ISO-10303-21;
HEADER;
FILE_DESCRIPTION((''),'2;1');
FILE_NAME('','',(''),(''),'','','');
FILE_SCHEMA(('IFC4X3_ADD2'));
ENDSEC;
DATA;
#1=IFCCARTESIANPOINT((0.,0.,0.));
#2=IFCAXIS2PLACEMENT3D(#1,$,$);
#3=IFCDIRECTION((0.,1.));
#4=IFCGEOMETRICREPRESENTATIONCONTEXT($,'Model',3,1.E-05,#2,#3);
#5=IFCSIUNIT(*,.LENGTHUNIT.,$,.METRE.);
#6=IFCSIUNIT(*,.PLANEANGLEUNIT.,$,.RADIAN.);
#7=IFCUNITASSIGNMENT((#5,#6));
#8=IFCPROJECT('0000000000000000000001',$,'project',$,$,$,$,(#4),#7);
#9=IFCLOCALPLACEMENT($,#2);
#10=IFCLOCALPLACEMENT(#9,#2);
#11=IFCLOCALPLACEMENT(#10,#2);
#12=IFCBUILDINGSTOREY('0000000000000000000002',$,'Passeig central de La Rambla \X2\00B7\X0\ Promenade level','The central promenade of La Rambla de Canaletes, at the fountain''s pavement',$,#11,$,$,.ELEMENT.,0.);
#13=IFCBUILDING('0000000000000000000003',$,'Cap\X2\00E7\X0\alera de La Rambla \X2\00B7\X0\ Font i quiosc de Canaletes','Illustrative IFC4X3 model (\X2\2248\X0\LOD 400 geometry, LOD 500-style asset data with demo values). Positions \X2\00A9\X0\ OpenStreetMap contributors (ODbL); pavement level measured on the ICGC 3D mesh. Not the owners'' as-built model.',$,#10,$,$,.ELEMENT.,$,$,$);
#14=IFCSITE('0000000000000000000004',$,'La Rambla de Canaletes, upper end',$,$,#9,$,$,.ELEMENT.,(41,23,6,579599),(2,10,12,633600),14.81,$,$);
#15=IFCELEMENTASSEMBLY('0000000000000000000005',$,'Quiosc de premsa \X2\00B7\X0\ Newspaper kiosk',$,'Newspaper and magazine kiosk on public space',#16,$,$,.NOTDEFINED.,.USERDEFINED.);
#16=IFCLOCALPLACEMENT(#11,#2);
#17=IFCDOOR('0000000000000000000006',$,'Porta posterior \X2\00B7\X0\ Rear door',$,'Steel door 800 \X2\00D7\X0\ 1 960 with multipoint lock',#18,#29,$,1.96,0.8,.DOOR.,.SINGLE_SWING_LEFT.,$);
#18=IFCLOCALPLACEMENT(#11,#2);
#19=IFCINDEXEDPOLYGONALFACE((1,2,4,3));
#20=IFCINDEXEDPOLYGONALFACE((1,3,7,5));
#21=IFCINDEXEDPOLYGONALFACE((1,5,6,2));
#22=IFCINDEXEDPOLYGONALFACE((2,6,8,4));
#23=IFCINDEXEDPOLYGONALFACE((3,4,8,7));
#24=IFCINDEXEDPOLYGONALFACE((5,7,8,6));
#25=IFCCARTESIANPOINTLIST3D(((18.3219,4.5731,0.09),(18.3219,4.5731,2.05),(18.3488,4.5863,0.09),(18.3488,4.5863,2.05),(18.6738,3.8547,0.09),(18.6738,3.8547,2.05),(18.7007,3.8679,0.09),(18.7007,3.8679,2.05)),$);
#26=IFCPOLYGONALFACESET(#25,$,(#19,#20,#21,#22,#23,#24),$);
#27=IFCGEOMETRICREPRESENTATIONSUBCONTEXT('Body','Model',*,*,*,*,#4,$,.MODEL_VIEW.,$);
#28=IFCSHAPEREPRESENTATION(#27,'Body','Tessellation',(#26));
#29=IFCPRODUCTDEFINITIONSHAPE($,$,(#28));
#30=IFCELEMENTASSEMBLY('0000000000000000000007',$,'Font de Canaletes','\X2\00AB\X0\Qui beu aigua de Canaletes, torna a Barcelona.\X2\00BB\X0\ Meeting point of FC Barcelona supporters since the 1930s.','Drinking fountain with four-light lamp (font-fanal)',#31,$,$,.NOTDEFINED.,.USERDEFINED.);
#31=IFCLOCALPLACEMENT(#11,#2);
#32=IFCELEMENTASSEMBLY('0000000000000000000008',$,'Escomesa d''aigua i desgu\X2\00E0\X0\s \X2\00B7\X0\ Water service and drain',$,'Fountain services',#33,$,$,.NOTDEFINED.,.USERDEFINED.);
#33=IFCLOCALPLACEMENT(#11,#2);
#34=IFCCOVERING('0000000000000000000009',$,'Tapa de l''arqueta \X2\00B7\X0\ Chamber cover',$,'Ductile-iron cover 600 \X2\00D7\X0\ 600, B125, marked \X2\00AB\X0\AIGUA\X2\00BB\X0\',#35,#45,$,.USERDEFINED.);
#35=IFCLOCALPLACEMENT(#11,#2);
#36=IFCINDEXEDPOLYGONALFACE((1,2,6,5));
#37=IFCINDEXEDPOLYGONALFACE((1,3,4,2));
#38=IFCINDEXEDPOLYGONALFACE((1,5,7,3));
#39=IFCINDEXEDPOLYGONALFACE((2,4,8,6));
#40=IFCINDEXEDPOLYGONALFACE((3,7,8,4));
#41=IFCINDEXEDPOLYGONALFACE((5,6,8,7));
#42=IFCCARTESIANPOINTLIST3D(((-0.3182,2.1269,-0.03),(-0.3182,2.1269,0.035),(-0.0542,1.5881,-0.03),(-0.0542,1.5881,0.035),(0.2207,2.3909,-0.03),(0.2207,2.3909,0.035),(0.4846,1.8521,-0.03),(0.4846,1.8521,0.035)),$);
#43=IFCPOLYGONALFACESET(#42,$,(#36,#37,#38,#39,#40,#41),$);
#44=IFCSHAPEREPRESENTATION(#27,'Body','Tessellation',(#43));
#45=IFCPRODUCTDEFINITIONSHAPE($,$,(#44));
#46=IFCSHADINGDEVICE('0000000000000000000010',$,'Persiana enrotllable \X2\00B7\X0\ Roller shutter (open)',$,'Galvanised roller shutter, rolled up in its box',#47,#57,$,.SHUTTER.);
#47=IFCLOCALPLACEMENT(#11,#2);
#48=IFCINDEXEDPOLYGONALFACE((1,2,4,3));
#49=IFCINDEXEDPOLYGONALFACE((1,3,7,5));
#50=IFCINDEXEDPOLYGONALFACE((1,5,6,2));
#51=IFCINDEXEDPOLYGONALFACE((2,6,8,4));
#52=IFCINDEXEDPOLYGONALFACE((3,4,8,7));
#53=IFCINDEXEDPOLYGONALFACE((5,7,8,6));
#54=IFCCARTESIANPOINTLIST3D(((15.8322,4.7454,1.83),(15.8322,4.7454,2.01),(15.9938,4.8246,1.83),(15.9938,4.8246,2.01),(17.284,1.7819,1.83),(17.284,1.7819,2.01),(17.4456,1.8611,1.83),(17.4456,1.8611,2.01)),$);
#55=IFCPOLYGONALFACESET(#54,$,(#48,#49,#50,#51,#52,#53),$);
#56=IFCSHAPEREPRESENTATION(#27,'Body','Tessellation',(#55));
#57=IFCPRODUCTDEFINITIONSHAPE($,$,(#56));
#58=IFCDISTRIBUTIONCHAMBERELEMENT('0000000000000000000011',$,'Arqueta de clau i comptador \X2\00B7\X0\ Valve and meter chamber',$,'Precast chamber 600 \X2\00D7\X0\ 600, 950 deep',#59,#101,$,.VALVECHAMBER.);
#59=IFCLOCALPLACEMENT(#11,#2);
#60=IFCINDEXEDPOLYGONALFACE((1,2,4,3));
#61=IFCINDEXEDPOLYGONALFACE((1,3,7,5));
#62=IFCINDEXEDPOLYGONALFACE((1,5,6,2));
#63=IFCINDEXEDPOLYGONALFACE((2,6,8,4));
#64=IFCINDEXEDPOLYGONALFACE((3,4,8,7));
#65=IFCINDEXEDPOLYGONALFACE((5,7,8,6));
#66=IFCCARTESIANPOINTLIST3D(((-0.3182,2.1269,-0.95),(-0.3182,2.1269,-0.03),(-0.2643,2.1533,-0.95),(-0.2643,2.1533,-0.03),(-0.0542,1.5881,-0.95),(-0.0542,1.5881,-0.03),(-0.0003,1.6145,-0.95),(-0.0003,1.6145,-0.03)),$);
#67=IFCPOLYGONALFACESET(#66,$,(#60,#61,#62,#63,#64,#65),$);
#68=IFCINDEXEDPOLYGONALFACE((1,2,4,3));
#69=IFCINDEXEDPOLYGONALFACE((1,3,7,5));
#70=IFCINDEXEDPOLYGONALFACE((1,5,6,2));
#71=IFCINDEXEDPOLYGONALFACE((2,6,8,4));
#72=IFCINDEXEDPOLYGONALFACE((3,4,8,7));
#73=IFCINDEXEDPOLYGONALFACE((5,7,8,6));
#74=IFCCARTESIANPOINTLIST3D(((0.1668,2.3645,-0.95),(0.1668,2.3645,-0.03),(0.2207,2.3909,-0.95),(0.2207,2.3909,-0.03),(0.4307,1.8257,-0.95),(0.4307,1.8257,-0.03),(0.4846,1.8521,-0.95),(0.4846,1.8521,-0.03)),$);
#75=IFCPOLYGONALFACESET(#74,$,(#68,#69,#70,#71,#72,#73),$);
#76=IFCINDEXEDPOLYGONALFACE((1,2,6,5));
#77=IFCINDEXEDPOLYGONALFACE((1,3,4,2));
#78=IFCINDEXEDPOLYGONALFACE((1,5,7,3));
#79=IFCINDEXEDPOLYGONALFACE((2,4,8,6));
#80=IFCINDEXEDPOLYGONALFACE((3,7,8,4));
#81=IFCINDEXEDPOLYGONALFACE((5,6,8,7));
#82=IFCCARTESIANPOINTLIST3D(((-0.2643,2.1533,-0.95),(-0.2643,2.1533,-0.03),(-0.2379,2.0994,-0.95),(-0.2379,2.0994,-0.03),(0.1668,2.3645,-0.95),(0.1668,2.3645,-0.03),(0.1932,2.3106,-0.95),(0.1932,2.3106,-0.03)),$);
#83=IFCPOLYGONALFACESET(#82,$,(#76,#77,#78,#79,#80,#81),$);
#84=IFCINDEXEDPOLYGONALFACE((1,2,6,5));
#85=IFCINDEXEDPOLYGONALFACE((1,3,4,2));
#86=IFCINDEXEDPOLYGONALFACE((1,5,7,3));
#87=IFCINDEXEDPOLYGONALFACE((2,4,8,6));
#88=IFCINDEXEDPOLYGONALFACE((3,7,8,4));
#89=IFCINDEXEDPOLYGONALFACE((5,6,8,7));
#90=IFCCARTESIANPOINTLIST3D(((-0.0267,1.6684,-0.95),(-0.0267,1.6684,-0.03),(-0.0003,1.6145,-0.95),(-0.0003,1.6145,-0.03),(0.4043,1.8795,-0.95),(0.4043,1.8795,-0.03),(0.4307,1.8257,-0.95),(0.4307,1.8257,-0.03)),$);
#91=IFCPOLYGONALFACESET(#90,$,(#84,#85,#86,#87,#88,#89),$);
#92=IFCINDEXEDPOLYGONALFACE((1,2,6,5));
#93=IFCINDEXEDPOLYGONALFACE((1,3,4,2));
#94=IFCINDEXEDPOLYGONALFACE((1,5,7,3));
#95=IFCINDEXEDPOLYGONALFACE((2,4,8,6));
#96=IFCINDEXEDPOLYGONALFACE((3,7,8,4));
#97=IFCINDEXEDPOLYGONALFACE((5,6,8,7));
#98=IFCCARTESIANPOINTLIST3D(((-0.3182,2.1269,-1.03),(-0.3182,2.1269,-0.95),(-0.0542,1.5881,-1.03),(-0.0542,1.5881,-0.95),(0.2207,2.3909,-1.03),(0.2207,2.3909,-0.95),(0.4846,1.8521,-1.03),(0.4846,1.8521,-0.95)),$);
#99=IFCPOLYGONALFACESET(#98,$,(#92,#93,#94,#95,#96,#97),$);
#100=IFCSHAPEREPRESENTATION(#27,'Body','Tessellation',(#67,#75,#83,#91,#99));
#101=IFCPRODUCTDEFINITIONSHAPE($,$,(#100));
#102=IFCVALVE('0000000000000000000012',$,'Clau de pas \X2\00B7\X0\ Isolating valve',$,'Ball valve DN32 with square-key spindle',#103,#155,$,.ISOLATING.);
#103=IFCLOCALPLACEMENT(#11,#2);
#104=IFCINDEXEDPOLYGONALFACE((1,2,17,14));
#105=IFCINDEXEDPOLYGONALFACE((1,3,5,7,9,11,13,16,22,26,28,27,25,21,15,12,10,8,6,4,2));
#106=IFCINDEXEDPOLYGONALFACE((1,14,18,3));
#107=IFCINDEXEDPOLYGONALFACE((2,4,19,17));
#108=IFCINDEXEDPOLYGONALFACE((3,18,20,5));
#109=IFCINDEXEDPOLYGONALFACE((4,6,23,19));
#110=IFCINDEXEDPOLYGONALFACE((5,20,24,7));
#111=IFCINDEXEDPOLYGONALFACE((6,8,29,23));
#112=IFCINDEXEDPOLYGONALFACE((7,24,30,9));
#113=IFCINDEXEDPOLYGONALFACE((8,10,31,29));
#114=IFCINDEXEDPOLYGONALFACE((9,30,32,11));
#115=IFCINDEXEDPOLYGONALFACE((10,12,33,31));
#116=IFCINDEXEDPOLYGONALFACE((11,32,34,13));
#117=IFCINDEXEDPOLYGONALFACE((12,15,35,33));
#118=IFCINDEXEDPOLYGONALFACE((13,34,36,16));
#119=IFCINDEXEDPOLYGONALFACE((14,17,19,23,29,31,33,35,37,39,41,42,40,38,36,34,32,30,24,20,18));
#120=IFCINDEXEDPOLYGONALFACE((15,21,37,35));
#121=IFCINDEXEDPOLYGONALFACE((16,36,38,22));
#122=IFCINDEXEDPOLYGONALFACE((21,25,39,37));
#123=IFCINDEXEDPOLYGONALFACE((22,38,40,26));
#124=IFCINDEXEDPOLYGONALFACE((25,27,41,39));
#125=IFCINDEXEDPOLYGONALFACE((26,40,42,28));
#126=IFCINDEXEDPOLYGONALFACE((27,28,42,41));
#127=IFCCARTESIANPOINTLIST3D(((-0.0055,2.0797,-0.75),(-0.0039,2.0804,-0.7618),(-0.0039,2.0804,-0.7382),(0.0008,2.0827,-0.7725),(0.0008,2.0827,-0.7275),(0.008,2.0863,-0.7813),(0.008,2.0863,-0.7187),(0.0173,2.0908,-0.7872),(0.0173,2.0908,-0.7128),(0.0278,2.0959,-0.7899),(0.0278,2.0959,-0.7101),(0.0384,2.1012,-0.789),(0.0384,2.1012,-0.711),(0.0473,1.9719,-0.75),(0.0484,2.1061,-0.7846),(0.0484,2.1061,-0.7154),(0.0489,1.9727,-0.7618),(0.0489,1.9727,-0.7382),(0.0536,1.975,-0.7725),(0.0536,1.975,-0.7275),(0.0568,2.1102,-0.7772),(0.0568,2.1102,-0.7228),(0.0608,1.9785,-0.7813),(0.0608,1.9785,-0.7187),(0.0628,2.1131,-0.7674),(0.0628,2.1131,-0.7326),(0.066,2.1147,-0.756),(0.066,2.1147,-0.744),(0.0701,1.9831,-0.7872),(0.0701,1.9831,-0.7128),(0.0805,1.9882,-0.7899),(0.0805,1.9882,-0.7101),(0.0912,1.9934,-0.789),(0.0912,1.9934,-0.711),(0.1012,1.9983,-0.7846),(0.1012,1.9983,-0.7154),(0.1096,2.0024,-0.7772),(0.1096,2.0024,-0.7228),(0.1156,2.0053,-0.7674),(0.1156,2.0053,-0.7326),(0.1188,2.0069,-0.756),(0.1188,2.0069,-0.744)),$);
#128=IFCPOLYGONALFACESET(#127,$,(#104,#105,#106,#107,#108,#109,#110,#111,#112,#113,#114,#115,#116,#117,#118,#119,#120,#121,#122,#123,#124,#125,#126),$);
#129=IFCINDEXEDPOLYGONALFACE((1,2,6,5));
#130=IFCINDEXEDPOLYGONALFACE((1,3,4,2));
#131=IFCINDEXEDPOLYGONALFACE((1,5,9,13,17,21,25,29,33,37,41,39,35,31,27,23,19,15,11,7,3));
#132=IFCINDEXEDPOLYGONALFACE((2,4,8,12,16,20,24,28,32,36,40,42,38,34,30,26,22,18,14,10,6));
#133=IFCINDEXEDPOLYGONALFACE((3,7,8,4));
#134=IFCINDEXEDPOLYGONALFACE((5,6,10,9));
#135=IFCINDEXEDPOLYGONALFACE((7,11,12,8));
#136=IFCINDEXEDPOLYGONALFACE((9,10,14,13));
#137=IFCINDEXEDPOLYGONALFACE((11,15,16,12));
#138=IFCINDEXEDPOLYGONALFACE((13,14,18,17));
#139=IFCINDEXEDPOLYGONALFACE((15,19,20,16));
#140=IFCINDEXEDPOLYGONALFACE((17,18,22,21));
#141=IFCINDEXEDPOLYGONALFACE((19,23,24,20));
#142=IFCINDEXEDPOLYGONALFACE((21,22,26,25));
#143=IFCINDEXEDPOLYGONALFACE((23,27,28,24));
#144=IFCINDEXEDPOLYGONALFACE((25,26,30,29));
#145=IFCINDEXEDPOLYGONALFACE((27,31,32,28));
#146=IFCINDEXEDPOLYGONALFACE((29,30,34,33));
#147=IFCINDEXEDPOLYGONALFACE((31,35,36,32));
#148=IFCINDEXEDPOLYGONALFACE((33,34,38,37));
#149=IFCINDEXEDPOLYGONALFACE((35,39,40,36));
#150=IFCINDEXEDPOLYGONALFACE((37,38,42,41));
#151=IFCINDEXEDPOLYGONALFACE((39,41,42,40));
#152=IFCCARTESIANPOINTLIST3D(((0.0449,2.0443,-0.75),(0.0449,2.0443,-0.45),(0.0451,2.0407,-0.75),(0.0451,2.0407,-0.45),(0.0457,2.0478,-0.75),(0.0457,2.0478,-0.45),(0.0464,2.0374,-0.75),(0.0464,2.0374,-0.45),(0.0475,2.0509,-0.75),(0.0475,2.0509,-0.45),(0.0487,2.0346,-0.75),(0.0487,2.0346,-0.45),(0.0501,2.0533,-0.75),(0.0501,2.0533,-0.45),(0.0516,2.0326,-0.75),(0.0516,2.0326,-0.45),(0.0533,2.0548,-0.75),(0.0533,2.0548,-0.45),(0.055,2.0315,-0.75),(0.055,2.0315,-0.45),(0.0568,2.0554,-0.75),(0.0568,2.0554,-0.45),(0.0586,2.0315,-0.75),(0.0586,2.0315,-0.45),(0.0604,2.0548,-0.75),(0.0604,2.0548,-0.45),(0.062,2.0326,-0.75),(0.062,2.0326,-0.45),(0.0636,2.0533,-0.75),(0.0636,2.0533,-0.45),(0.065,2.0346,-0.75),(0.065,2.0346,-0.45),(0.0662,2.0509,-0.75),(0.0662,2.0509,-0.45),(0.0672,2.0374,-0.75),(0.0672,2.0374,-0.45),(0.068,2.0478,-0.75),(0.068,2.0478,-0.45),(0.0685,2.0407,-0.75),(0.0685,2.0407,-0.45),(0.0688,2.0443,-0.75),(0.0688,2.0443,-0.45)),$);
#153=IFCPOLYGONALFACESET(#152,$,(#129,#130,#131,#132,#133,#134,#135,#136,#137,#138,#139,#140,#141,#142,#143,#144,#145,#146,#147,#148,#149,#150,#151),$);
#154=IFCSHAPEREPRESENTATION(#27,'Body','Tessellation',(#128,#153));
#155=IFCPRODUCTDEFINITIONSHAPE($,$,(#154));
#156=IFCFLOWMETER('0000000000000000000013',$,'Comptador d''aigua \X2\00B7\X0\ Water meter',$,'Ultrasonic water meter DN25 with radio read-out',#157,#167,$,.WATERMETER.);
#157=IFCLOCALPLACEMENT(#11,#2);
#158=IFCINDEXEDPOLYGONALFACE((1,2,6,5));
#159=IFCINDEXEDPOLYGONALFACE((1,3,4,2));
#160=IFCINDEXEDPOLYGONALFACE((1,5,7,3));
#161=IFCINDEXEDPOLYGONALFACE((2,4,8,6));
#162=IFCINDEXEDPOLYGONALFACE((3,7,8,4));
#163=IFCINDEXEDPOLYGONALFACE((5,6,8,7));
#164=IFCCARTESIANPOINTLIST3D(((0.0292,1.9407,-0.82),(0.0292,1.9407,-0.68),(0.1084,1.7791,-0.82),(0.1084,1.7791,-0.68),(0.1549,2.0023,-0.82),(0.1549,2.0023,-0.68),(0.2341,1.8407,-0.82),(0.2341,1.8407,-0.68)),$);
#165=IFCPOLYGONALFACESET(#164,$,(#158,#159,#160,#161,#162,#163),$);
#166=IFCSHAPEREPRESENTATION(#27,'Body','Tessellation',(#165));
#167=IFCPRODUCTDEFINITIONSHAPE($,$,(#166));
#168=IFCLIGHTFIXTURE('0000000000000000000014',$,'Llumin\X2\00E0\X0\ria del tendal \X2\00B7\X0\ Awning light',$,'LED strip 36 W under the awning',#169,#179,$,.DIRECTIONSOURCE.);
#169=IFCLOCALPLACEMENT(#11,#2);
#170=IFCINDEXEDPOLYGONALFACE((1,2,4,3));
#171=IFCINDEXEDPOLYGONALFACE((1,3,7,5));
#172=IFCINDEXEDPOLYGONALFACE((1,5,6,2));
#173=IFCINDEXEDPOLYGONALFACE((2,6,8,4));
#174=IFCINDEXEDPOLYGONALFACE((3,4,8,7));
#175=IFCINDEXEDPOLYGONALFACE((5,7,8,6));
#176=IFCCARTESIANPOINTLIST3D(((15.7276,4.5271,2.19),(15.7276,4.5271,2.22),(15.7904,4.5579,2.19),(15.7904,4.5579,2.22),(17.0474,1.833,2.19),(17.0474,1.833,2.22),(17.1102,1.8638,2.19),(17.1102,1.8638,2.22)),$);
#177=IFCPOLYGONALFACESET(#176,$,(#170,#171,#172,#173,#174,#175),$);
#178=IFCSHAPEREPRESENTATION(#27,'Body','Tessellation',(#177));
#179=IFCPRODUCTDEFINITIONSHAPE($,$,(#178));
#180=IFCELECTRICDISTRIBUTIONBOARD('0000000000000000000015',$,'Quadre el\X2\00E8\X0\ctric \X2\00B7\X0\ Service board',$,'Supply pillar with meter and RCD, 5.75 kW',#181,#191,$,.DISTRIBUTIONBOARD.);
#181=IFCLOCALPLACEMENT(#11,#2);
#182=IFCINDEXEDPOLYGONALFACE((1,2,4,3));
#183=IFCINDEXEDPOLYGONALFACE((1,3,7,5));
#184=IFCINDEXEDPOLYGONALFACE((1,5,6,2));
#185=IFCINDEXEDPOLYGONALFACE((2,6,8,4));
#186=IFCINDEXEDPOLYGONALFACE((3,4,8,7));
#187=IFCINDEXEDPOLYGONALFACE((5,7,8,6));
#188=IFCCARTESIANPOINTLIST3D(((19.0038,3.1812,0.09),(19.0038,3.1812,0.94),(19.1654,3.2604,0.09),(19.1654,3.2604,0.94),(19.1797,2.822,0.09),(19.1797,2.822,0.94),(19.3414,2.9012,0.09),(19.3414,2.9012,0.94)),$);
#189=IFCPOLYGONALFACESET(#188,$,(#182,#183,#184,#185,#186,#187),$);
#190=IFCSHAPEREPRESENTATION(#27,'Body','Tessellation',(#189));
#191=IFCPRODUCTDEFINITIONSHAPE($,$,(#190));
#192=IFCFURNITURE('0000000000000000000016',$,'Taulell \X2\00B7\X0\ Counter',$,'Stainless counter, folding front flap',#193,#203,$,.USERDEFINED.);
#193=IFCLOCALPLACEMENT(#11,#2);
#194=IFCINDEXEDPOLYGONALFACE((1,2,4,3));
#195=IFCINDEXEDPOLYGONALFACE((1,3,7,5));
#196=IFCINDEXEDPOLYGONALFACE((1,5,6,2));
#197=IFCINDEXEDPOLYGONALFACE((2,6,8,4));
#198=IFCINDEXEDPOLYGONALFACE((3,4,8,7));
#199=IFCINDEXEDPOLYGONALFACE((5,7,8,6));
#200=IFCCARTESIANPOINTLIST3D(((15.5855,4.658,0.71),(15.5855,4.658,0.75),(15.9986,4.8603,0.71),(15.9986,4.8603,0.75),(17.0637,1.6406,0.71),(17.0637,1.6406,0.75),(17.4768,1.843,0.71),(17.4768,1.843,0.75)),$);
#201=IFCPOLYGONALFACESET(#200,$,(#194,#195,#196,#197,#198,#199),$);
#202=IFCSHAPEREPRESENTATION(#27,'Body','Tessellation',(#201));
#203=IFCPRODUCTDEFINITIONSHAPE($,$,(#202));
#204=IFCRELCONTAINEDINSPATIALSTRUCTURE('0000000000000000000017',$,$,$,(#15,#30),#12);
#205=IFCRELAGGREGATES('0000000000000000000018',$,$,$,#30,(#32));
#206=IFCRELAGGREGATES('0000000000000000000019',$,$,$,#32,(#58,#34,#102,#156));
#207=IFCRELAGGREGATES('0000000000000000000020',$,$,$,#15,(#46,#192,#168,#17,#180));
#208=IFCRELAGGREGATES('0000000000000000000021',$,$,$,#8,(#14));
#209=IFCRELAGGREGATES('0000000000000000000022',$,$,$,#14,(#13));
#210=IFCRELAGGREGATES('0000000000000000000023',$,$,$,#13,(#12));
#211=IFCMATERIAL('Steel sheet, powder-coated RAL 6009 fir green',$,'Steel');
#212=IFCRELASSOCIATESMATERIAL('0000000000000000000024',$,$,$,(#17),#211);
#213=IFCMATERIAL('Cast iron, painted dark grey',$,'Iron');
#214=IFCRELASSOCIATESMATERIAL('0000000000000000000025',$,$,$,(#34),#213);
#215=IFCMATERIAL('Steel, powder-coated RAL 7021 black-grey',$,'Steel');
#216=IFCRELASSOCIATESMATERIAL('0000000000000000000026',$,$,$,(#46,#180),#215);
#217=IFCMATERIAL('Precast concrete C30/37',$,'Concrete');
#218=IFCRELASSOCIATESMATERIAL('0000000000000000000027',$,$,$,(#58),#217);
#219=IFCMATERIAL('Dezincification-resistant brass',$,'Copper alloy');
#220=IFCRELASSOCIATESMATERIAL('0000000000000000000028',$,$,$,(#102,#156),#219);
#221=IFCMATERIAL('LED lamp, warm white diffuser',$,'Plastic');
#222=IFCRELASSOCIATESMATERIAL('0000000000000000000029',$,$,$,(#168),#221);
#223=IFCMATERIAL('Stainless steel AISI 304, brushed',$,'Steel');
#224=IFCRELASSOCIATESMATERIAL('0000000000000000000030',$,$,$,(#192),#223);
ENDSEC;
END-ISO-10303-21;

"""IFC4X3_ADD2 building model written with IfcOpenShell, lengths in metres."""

from ifc_helpers import new_model, si_unit, direction, frame, frame_2d, origin, origin_2d_with_axis, place, context, subcontext, project, spatial, rectangle, circle, extrude, material, element, aggregate, save


model = new_model("IFC4X3_ADD2")

# Units and contexts
model_context = context("Model", 3, precision=1e-05, world=origin(), true_north=direction((0.0, 1.0)))
body_context = subcontext(model_context, "Body", "Model", "MODEL_VIEW")
ifc_project = project(units=[si_unit("LENGTHUNIT", "METRE"), si_unit("PLANEANGLEUNIT", "RADIAN")], contexts=[model_context])

# Site, building, storey
site_placement = place(None, origin())
site = spatial("IfcSite", under=ifc_project, at=site_placement, Name="La Rambla de Canaletes, upper end", CompositionType="ELEMENT", RefLatitude=(41, 23, 6, 579599), RefLongitude=(2, 10, 12, 633600), RefElevation=14.81)
building_placement = place(site_placement, origin())
building = spatial("IfcBuilding", under=site, at=building_placement, Name="Capçalera de La Rambla · Font i quiosc de Canaletes", Description="Illustrative IFC4X3 model (≈LOD 400 geometry, LOD 500-style asset data with demo values). Positions © OpenStreetMap contributors (ODbL); pavement level measured on the ICGC 3D mesh. Not the owners' as-built model.", CompositionType="ELEMENT")
storey_placement = place(building_placement, origin())
storey = spatial("IfcBuildingStorey", under=building, at=storey_placement, Name="Passeig central de La Rambla · Promenade level", Description="The central promenade of La Rambla de Canaletes, at the fountain's pavement", CompositionType="ELEMENT", Elevation=0.0)

# Element assembly
assembly_1_placement = place(building_placement, origin())
assembly_1 = element("IfcElementAssembly", 1, at=assembly_1_placement, inside=storey, Name="Quiosc de premsa · Newspaper kiosk", ObjectType="Newspaper and magazine kiosk on public space", AssemblyPlace="NOTDEFINED", PredefinedType="USERDEFINED")
ifc_material_1 = material(Name="Steel, powder-coated RAL 7021 black-grey", Category="Steel")

# Shared definitions
ifc_material_2 = material(Name="Steel sheet, powder-coated RAL 6009 fir green", Category="Steel")

# Door
door_placement = place(building_placement, origin())
door = element("IfcDoor", 2, at=door_placement, material=ifc_material_2, Name="Porta posterior · Rear door", ObjectType="Steel door 800 × 1 960 with multipoint lock", OperationType="SINGLE_SWING_LEFT", OverallHeight=1.96, OverallWidth=0.8, PredefinedType="DOOR", context=body_context, shape_type="SweptSolid", body=[
    extrude(rectangle(XDim=0.8, YDim=0.03, at=frame_2d((0.0, 0.0), x_axis=(0.439939, -0.898028))), frame((18.5113, 4.2205, 0.09)), (0.0, 0.0, 1.0), 1.96),
])

# Element assemblies, covering
assembly_2_placement = place(building_placement, origin())
assembly_2 = element("IfcElementAssembly", 3, at=assembly_2_placement, inside=storey, Name="Font de Canaletes", Description="«Qui beu aigua de Canaletes, torna a Barcelona.» Meeting point of FC Barcelona supporters since the 1930s.", ObjectType="Drinking fountain with four-light lamp (font-fanal)", AssemblyPlace="NOTDEFINED", PredefinedType="USERDEFINED")
assembly_3_placement = place(building_placement, origin())
assembly_3 = element("IfcElementAssembly", 4, at=assembly_3_placement, Name="Escomesa d'aigua i desguàs · Water service and drain", ObjectType="Fountain services", AssemblyPlace="NOTDEFINED", PredefinedType="USERDEFINED")
aggregate(assembly_2, [assembly_3])
ifc_material_3 = material(Name="Cast iron, painted dark grey", Category="Iron")
covering_1_placement = place(building_placement, origin())
covering_1 = element("IfcCovering", 5, at=covering_1_placement, material=ifc_material_3, Name="Tapa de l'arqueta · Chamber cover", ObjectType="Ductile-iron cover 600 × 600, B125, marked «AIGUA»", PredefinedType="USERDEFINED", context=body_context, shape_type="SweptSolid", body=[
    extrude(rectangle(XDim=0.6, YDim=0.6, at=frame_2d((0.0, 0.0), x_axis=(0.439939, -0.898028))), frame((0.0832, 1.9895, -0.03)), (0.0, 0.0, 1.0), 0.065),
])

# Shading device
shading_device_1_placement = place(building_placement, origin())
shading_device_1 = element("IfcShadingDevice", 6, at=shading_device_1_placement, material=ifc_material_1, Name="Persiana enrotllable · Roller shutter (open)", ObjectType="Galvanised roller shutter, rolled up in its box", PredefinedType="SHUTTER", context=body_context, shape_type="SweptSolid", body=[
    extrude(rectangle(XDim=3.3, YDim=0.18, at=frame_2d((0.0, 0.0), x_axis=(0.439939, -0.898028))), frame((16.6389, 3.3033, 1.83)), (0.0, 0.0, 1.0), 0.18),
])

# Distribution chamber element
ifc_material_4 = material(Name="Precast concrete C30/37", Category="Concrete")
distribution_chamber_element_placement = place(building_placement, origin())
distribution_chamber_element = element("IfcDistributionChamberElement", 7, at=distribution_chamber_element_placement, material=ifc_material_4, Name="Arqueta de clau i comptador · Valve and meter chamber", ObjectType="Precast chamber 600 × 600, 950 deep", PredefinedType="VALVECHAMBER", context=body_context, shape_type="SweptSolid", body=[
    extrude(rectangle(XDim=0.6, YDim=0.06, at=frame_2d((0.0, 0.0), x_axis=(0.439939, -0.898028))), frame((-0.1592, 1.8707, -0.95)), (0.0, 0.0, 1.0), 0.92),
    extrude(rectangle(XDim=0.6, YDim=0.06, at=frame_2d((0.0, 0.0), x_axis=(0.439939, -0.898028))), frame((0.3257, 2.1083, -0.95)), (0.0, 0.0, 1.0), 0.92),
    extrude(rectangle(XDim=0.06, YDim=0.48, at=frame_2d((0.0, 0.0), x_axis=(0.439939, -0.898028))), frame((-0.0356, 2.232, -0.95)), (0.0, 0.0, 1.0), 0.92),
    extrude(rectangle(XDim=0.06, YDim=0.48, at=frame_2d((0.0, 0.0), x_axis=(0.439939, -0.898028))), frame((0.202, 1.747, -0.95)), (0.0, 0.0, 1.0), 0.92),
    extrude(rectangle(XDim=0.6, YDim=0.6, at=frame_2d((0.0, 0.0), x_axis=(0.439939, -0.898028))), frame((0.0832, 1.9895, -1.03)), (0.0, 0.0, 1.0), 0.08),
])

# Valve
ifc_material_5 = material(Name="Dezincification-resistant brass", Category="Copper alloy")
valve_placement = place(building_placement, origin())
valve = element("IfcValve", 8, at=valve_placement, material=ifc_material_5, Name="Clau de pas · Isolating valve", ObjectType="Ball valve DN32 with square-key spindle", PredefinedType="ISOLATING", context=body_context, shape_type="SweptSolid", body=[
    extrude(circle(Radius=0.04, at=origin_2d_with_axis()), frame((0.0304, 2.0973, -0.75), z_axis=(0.439939, -0.898028, 0.0), x_axis=(-0.898028, -0.439939, 0.0)), (0.0, 0.0, 1.0), 0.12),
    extrude(circle(Radius=0.012, at=origin_2d_with_axis()), frame((0.0568, 2.0434, -0.75), z_axis=(0.0, 0.0, 1.0), x_axis=(0.0, 1.0, 0.0)), (0.0, 0.0, 1.0), 0.3),
])

# Flow meter
flow_meter_placement = place(building_placement, origin())
flow_meter = element("IfcFlowMeter", 9, at=flow_meter_placement, material=ifc_material_5, Name="Comptador d'aigua · Water meter", ObjectType="Ultrasonic water meter DN25 with radio read-out", PredefinedType="WATERMETER", context=body_context, shape_type="SweptSolid", body=[
    extrude(rectangle(XDim=0.18, YDim=0.14, at=frame_2d((0.0, 0.0), x_axis=(0.439939, -0.898028))), frame((0.1316, 1.8907, -0.82)), (0.0, 0.0, 1.0), 0.14),
])
aggregate(assembly_3, [distribution_chamber_element, covering_1, valve, flow_meter])

# Light fixture
ifc_material_6 = material(Name="LED lamp, warm white diffuser", Category="Plastic")
light_fixture_placement = place(building_placement, origin())
light_fixture = element("IfcLightFixture", 10, at=light_fixture_placement, material=ifc_material_6, Name="Lluminària del tendal · Awning light", ObjectType="LED strip 36 W under the awning", PredefinedType="DIRECTIONSOURCE", context=body_context, shape_type="SweptSolid", body=[
    extrude(rectangle(XDim=3.0, YDim=0.07, at=frame_2d((0.0, 0.0), x_axis=(0.439939, -0.898028))), frame((16.4189, 3.1955, 2.19)), (0.0, 0.0, 1.0), 0.03),
])

# Electric distribution board
electric_distribution_board_placement = place(building_placement, origin())
electric_distribution_board = element("IfcElectricDistributionBoard", 11, at=electric_distribution_board_placement, material=ifc_material_1, Name="Quadre elèctric · Service board", ObjectType="Supply pillar with meter and RCD, 5.75 kW", PredefinedType="DISTRIBUTIONBOARD", context=body_context, shape_type="SweptSolid", body=[
    extrude(rectangle(XDim=0.4, YDim=0.18, at=frame_2d((0.0, 0.0), x_axis=(0.439939, -0.898028))), frame((19.1726, 3.0412, 0.09)), (0.0, 0.0, 1.0), 0.85),
])

# Furniture
ifc_material_7 = material(Name="Stainless steel AISI 304, brushed", Category="Steel")
furniture_1_placement = place(building_placement, origin())
furniture_1 = element("IfcFurniture", 12, at=furniture_1_placement, material=ifc_material_7, Name="Taulell · Counter", ObjectType="Stainless counter, folding front flap", PredefinedType="USERDEFINED", context=body_context, shape_type="SweptSolid", body=[
    extrude(rectangle(XDim=3.36, YDim=0.46, at=frame_2d((0.0, 0.0), x_axis=(0.439939, -0.898028))), frame((16.5311, 3.2505, 0.71)), (0.0, 0.0, 1.0), 0.04),
])

aggregate(assembly_1, [shading_device_1, furniture_1, light_fixture, door, electric_distribution_board])

save(model, "model.ifc")
